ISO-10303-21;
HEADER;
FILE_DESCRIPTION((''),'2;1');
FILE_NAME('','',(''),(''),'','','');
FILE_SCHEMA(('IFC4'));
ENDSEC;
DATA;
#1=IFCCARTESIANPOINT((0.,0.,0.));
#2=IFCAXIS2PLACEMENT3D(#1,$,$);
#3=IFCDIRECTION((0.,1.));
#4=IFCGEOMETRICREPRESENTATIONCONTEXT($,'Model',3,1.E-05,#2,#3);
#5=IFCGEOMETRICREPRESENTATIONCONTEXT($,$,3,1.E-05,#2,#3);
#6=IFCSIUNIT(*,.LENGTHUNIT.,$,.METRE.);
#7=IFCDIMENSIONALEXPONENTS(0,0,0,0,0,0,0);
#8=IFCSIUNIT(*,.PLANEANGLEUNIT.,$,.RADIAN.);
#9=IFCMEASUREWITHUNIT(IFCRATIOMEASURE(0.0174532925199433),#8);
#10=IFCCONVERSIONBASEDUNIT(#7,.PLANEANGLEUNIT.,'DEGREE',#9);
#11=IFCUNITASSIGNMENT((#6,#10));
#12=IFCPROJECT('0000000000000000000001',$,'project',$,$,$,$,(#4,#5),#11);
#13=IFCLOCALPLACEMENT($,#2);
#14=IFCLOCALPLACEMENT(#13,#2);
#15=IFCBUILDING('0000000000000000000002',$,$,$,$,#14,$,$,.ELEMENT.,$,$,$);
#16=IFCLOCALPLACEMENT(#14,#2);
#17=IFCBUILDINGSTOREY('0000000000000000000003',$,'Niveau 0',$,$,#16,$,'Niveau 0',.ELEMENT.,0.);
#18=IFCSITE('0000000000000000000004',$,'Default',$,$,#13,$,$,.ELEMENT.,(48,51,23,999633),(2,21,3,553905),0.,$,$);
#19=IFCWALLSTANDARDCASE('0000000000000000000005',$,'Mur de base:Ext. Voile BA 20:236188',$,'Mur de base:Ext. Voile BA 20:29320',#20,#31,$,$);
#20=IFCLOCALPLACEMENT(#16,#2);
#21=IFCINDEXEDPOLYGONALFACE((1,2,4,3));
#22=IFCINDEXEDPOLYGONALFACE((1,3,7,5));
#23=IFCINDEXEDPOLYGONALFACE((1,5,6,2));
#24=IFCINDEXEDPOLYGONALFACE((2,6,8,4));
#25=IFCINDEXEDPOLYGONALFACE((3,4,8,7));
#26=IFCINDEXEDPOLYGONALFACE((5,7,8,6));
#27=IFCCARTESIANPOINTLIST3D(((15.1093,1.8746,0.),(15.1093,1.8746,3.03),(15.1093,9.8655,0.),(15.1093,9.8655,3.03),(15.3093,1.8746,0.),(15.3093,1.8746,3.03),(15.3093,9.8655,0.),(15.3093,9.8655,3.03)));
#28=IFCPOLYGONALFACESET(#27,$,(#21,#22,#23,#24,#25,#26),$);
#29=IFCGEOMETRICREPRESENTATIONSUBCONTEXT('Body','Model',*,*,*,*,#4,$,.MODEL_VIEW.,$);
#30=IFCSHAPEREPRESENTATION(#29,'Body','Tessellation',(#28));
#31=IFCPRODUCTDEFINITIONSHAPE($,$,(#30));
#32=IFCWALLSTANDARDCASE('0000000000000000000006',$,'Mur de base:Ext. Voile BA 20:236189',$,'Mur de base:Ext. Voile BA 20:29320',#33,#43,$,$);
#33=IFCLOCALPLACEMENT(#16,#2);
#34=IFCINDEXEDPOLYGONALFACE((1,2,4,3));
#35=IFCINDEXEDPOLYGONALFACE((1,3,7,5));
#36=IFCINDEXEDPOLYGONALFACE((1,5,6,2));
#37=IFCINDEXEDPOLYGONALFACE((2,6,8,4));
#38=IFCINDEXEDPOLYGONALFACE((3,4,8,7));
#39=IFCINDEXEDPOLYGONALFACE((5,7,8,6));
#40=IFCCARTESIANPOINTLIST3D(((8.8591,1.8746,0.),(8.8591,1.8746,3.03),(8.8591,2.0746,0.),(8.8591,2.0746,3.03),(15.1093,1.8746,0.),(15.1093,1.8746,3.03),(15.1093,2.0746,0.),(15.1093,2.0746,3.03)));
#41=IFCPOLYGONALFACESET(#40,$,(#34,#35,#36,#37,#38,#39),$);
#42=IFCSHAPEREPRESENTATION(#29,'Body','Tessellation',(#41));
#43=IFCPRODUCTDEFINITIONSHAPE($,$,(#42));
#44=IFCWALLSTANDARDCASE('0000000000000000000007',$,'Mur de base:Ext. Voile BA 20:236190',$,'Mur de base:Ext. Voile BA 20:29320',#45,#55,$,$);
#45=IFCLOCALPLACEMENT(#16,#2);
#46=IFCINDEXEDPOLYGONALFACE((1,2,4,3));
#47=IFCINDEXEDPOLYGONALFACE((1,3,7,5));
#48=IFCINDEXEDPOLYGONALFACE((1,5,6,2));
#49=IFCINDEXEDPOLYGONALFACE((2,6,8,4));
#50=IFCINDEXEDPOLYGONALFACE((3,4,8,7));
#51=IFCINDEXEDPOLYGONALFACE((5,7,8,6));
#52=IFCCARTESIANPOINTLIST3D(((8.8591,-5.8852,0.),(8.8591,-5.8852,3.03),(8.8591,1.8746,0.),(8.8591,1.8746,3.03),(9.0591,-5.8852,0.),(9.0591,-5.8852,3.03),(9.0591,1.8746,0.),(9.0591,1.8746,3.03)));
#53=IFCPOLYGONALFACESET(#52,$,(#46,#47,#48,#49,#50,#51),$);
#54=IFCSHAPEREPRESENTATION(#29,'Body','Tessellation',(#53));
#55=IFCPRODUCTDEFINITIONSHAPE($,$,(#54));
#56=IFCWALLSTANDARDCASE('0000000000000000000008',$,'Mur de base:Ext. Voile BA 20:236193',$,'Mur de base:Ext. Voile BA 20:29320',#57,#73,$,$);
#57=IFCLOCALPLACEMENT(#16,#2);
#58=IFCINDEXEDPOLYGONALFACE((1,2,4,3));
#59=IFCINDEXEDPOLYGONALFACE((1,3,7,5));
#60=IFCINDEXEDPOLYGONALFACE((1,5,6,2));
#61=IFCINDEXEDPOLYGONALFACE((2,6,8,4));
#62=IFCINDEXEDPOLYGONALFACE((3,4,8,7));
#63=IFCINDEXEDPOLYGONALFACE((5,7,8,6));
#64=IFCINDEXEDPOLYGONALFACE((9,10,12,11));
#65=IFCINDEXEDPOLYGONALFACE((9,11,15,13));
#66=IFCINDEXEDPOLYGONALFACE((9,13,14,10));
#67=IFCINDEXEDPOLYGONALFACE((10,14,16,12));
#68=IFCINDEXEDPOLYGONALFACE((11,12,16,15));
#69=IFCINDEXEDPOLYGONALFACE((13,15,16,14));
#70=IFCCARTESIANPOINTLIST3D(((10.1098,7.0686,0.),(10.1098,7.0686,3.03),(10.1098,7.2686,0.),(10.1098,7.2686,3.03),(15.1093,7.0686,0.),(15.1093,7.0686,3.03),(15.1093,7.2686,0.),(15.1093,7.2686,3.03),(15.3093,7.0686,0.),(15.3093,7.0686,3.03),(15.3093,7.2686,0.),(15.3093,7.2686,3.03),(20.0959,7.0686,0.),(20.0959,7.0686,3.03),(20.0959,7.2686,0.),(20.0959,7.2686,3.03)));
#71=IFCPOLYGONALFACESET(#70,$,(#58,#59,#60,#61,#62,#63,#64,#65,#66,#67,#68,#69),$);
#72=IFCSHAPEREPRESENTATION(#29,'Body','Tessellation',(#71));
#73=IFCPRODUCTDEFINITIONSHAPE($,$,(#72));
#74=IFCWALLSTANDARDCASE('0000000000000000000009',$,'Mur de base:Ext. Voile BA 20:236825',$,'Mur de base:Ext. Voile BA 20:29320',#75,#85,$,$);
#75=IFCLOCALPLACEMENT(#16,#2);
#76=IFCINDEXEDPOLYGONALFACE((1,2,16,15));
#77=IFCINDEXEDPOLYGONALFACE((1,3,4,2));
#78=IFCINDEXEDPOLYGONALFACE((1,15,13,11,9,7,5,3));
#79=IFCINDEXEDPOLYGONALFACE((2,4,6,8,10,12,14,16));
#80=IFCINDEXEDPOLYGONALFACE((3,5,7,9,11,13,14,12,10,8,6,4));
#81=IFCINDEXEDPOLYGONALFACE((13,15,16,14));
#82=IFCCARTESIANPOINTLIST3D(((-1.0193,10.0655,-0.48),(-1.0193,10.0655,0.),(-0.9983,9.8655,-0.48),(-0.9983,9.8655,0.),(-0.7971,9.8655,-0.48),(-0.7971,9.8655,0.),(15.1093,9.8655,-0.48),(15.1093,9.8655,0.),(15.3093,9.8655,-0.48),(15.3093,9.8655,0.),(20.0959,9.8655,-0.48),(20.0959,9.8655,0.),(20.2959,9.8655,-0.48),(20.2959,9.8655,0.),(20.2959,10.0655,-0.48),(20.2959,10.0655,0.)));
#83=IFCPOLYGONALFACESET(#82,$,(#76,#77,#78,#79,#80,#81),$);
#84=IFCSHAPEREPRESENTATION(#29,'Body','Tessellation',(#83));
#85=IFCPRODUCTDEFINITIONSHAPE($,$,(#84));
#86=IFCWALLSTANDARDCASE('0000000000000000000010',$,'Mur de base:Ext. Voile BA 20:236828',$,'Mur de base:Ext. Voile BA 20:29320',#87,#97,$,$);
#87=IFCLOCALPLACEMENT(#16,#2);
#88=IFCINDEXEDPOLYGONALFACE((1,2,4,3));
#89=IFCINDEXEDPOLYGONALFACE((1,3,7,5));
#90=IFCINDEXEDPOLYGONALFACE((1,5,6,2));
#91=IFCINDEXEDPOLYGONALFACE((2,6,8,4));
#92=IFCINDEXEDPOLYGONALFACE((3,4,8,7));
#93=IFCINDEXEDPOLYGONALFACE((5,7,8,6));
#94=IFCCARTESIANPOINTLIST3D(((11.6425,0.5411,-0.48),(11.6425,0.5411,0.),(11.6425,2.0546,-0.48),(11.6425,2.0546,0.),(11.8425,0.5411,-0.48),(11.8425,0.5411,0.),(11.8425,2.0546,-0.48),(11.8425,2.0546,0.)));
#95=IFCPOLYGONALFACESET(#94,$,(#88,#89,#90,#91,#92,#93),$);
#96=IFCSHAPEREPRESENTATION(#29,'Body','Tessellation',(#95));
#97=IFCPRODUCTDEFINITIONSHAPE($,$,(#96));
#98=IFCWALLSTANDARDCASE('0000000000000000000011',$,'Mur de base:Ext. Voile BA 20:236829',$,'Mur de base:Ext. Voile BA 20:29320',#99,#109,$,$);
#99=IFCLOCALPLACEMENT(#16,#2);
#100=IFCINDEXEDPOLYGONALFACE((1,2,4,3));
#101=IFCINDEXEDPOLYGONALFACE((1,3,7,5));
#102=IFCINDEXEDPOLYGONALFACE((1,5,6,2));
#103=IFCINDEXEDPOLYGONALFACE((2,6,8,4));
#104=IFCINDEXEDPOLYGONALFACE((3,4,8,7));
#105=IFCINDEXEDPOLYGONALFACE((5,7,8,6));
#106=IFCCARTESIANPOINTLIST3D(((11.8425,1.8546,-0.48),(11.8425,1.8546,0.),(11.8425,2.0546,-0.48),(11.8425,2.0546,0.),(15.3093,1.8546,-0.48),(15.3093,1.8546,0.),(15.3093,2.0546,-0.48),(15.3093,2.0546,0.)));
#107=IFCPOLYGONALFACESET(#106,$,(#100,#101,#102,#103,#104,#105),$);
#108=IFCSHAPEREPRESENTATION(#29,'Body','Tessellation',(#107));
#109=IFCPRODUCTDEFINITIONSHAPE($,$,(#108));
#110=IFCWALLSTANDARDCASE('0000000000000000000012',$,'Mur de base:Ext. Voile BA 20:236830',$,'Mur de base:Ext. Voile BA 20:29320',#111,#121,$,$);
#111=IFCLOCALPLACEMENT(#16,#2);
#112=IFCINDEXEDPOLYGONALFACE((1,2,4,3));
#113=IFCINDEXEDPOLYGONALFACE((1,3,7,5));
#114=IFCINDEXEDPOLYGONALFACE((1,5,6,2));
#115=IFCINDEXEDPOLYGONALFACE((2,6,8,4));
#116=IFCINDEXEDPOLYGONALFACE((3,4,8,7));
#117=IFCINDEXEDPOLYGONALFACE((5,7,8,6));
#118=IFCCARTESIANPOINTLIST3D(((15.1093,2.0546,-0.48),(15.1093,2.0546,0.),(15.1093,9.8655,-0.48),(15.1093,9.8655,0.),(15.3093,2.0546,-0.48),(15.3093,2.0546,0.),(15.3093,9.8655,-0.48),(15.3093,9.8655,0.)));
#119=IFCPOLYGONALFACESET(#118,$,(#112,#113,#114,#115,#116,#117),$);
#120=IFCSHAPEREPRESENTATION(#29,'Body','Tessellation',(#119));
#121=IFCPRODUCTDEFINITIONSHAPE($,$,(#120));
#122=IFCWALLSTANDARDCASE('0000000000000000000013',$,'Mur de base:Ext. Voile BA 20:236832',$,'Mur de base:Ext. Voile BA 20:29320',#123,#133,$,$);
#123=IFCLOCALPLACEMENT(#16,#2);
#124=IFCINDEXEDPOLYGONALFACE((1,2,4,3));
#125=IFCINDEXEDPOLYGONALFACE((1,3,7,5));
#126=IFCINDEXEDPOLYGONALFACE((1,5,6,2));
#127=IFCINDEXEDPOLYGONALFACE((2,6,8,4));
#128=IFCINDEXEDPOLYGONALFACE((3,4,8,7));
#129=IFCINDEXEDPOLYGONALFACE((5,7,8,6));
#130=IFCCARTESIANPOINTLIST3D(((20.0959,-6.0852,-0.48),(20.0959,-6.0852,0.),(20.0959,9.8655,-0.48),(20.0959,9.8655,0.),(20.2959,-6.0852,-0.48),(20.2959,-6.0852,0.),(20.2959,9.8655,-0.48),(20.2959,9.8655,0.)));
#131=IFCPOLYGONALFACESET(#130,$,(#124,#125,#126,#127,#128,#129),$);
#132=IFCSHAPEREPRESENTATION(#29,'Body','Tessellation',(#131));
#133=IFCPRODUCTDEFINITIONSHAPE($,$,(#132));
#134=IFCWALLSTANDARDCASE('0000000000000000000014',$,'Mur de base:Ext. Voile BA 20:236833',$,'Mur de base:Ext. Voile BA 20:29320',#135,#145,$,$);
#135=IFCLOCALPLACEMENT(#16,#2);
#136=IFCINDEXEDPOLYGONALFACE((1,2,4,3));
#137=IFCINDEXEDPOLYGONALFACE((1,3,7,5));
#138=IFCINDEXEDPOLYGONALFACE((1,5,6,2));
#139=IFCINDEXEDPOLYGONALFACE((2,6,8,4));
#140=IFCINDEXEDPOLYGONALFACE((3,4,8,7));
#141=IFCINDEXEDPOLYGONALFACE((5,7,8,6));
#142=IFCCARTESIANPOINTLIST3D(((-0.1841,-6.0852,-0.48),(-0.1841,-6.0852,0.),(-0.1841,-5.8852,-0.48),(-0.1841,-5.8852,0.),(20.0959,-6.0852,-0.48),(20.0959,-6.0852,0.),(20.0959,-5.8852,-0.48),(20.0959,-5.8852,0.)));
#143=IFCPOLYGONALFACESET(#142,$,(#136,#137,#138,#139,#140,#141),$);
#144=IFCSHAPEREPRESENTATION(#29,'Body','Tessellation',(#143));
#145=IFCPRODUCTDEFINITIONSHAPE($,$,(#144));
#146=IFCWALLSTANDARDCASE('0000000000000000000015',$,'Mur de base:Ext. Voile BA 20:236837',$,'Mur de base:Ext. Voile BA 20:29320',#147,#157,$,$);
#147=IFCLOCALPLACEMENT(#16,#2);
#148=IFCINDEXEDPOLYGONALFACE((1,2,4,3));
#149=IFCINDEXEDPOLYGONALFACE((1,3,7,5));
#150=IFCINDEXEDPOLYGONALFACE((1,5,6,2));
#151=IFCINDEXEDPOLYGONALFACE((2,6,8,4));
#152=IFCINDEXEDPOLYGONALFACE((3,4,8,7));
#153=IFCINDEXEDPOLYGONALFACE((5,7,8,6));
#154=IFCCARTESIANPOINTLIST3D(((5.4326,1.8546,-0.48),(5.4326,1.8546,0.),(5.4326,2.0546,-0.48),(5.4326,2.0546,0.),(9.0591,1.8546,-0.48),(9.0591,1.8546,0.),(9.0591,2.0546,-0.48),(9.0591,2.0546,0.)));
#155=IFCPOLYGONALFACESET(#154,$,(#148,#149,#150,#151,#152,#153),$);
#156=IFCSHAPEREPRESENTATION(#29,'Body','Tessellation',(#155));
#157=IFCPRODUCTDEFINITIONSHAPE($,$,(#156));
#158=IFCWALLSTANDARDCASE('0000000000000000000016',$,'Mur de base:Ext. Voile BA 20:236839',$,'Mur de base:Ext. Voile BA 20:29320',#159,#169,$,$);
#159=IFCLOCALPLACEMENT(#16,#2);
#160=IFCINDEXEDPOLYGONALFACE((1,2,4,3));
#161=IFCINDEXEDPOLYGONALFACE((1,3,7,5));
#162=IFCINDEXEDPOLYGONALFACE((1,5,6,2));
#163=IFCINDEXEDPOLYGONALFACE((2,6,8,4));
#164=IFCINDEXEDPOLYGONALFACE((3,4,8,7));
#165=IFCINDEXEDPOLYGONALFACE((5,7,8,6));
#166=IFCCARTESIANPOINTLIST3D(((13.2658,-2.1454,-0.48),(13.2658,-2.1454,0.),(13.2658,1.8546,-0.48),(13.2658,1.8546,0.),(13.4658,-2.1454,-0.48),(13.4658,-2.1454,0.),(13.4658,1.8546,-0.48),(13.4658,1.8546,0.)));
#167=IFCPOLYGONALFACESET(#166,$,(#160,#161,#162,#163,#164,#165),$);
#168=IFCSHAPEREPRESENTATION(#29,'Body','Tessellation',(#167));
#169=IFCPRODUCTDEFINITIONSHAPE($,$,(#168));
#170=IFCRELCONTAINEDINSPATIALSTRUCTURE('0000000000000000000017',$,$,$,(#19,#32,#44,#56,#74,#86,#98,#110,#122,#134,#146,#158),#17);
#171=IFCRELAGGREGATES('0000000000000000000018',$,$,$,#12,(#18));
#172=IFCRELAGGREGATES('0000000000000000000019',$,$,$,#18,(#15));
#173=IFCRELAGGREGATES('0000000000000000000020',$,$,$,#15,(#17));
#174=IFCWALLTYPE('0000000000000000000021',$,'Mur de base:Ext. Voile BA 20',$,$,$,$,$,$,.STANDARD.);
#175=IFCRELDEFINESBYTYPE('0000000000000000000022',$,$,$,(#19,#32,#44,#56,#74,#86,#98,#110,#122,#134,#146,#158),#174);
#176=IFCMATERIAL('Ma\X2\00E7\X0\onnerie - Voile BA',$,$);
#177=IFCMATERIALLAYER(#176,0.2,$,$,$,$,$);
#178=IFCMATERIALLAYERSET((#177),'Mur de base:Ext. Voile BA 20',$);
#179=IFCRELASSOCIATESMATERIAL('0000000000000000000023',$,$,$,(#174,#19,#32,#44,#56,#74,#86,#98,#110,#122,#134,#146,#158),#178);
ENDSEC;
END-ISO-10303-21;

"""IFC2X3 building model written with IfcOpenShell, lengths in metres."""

from ifc_helpers import new_model, entity, si_unit, converted_unit, direction, frame, frame_2d, origin, origin_2d_with_axis, place, context, subcontext, project, spatial, polyline, rectangle, outline, extrude, material, layer, layer_set, layer_usage, type_object, element, save


model = new_model("IFC2X3")

# Units and contexts
model_context = context("Model", 3, precision=1e-05, world=origin(), true_north=direction((0.0, 1.0)))
context_of_model = context(None, 3, precision=1e-05, world=origin(), true_north=direction((0.0, 1.0)))
body_context = subcontext(model_context, "Body", "Model", "MODEL_VIEW")
ifc_project = project(units=[si_unit("LENGTHUNIT", "METRE"), converted_unit("PLANEANGLEUNIT", "DEGREE", entity("IfcRatioMeasure", 0.0174532925199433), si_unit("PLANEANGLEUNIT", "RADIAN"), dimensions=[0, 0, 0, 0, 0, 0, 0])], contexts=[model_context, context_of_model])

# Site, building, storey
site_placement = place(None, origin())
site = spatial("IfcSite", under=ifc_project, at=site_placement, Name="Default", CompositionType="ELEMENT", RefLatitude=(48, 51, 23, 999633), RefLongitude=(2, 21, 3, 553905), RefElevation=0.0)
building_placement = place(site_placement, origin())
building = spatial("IfcBuilding", under=site, at=building_placement, CompositionType="ELEMENT")
storey_placement = place(building_placement, origin())
storey = spatial("IfcBuildingStorey", under=building, at=storey_placement, Name="Niveau 0", LongName="Niveau 0", CompositionType="ELEMENT", Elevation=0.0)

# Shared definitions
ifc_material = material(Name="Maçonnerie - Voile BA")
ifc_layer = layer(ifc_material, 0.2)
ifc_layer_set = layer_set([ifc_layer], Name="Mur de base:Ext. Voile BA 20")
wall_type = type_object("IfcWallType", Name="Mur de base:Ext. Voile BA 20", PredefinedType="STANDARD", material=ifc_layer_set)

# Walls
ifc_layer_usage_1 = layer_usage(ifc_layer_set, "AXIS2", "NEGATIVE", 0.1)
wall_1_placement = place(storey_placement, frame((15.2093, 9.8655, 0.0), z_axis=(0.0, 0.0, 1.0), x_axis=(0.0, -1.0, 0.0)))
element("IfcWallStandardCase", 1, at=wall_1_placement, inside=storey, type_object=wall_type, material=ifc_layer_usage_1, Name="Mur de base:Ext. Voile BA 20:236188", ObjectType="Mur de base:Ext. Voile BA 20:29320", context=body_context, shape_type="SweptSolid", body=[
    extrude(rectangle(XDim=7.9908, YDim=0.2, at=frame_2d((3.9954, 0.0), x_axis=(-1.0, 0.0))), origin(), (0.0, 0.0, 1.0), 3.03),
])
ifc_layer_usage_2 = layer_usage(ifc_layer_set, "AXIS2", "NEGATIVE", 0.1)
wall_2_placement = place(storey_placement, frame((15.1093, 1.9746, 0.0), z_axis=(0.0, 0.0, 1.0), x_axis=(-1.0, 0.0, 0.0)))
element("IfcWallStandardCase", 2, at=wall_2_placement, inside=storey, type_object=wall_type, material=ifc_layer_usage_2, Name="Mur de base:Ext. Voile BA 20:236189", ObjectType="Mur de base:Ext. Voile BA 20:29320", context=body_context, shape_type="SweptSolid", body=[
    extrude(rectangle(XDim=6.2503, YDim=0.2, at=frame_2d((3.1251, 0.0), x_axis=(-1.0, 0.0))), origin(), (0.0, 0.0, 1.0), 3.03),
])
ifc_layer_usage_3 = layer_usage(ifc_layer_set, "AXIS2", "NEGATIVE", 0.1)
wall_3_placement = place(storey_placement, frame((8.9591, 1.8746, 0.0), z_axis=(0.0, 0.0, 1.0), x_axis=(0.0, -1.0, 0.0)))
element("IfcWallStandardCase", 3, at=wall_3_placement, inside=storey, type_object=wall_type, material=ifc_layer_usage_3, Name="Mur de base:Ext. Voile BA 20:236190", ObjectType="Mur de base:Ext. Voile BA 20:29320", context=body_context, shape_type="SweptSolid", body=[
    extrude(rectangle(XDim=7.7598, YDim=0.2, at=frame_2d((3.8799, 0.0), x_axis=(-1.0, 0.0))), origin(), (0.0, 0.0, 1.0), 3.03),
])

# Wall, opening
ifc_layer_usage_4 = layer_usage(ifc_layer_set, "AXIS2", "NEGATIVE", 0.1)
wall_4_placement = place(storey_placement, frame((20.0959, 7.1686, 0.0), z_axis=(0.0, 0.0, 1.0), x_axis=(-1.0, 0.0, 0.0)))
wall_4 = element("IfcWallStandardCase", 4, at=wall_4_placement, inside=storey, type_object=wall_type, material=ifc_layer_usage_4, Name="Mur de base:Ext. Voile BA 20:236193", ObjectType="Mur de base:Ext. Voile BA 20:29320", context=body_context, shape_type="SweptSolid", body=[
    extrude(rectangle(XDim=9.9862, YDim=0.2, at=frame_2d((4.9931, 0.0), x_axis=(-1.0, 0.0))), origin(), (0.0, 0.0, 1.0), 3.03),
])
opening_1_placement = place(storey_placement, frame((20.0959, 7.1686, 0.0), z_axis=(0.0, 0.0, 1.0), x_axis=(-1.0, 0.0, 0.0)))
element("IfcOpeningElement", 5, at=opening_1_placement, cuts=wall_4, ObjectType="Opening", context=body_context, shape_type="SweptSolid", body=[
    extrude(rectangle(XDim=3.03, YDim=0.2, at=origin_2d_with_axis()), frame((4.9866, 0.0, 1.515), z_axis=(-1.0, 0.0, 0.0), x_axis=(0.0, 0.0, 1.0)), (0.0, 0.0, 1.0), 0.2),
])

# Walls
ifc_layer_usage_5 = layer_usage(ifc_layer_set, "AXIS2", "NEGATIVE", 0.1)
wall_5_placement = place(storey_placement, frame((20.2959, 9.9655, -0.48), z_axis=(0.0, 0.0, 1.0), x_axis=(-1.0, 0.0, 0.0)))
element("IfcWallStandardCase", 6, at=wall_5_placement, inside=storey, type_object=wall_type, material=ifc_layer_usage_5, Name="Mur de base:Ext. Voile BA 20:236825", ObjectType="Mur de base:Ext. Voile BA 20:29320", context=body_context, shape_type="SweptSolid", body=[
    extrude(outline(polyline([(21.3152, -0.1), (21.2942, 0.1), (21.0931, 0.1), (5.1866, 0.1), (4.9866, 0.1), (0.2, 0.1), (0.0, 0.1), (0.0, -0.1), (21.3152, -0.1)])), origin(), (0.0, 0.0, 1.0), 0.48),
])
ifc_layer_usage_6 = layer_usage(ifc_layer_set, "AXIS2", "NEGATIVE", 0.1)
wall_6_placement = place(storey_placement, frame((11.7425, 0.5411, -0.48), z_axis=(0.0, 0.0, 1.0), x_axis=(0.0, 1.0, 0.0)))
element("IfcWallStandardCase", 7, at=wall_6_placement, inside=storey, type_object=wall_type, material=ifc_layer_usage_6, Name="Mur de base:Ext. Voile BA 20:236828", ObjectType="Mur de base:Ext. Voile BA 20:29320", context=body_context, shape_type="SweptSolid", body=[
    extrude(rectangle(XDim=1.5134, YDim=0.2, at=frame_2d((0.7567, 0.0), x_axis=(-1.0, 0.0))), origin(), (0.0, 0.0, 1.0), 0.48),
])
ifc_layer_usage_7 = layer_usage(ifc_layer_set, "AXIS2", "NEGATIVE", 0.1)
wall_7_placement = place(storey_placement, frame((11.8425, 1.9546, -0.48)))
element("IfcWallStandardCase", 8, at=wall_7_placement, inside=storey, type_object=wall_type, material=ifc_layer_usage_7, Name="Mur de base:Ext. Voile BA 20:236829", ObjectType="Mur de base:Ext. Voile BA 20:29320", context=body_context, shape_type="SweptSolid", body=[
    extrude(rectangle(XDim=3.4668, YDim=0.2, at=frame_2d((1.7334, 0.0), x_axis=(-1.0, 0.0))), origin(), (0.0, 0.0, 1.0), 0.48),
])
ifc_layer_usage_8 = layer_usage(ifc_layer_set, "AXIS2", "NEGATIVE", 0.1)
wall_8_placement = place(storey_placement, frame((15.2093, 2.0546, -0.48), z_axis=(0.0, 0.0, 1.0), x_axis=(0.0, 1.0, 0.0)))
element("IfcWallStandardCase", 9, at=wall_8_placement, inside=storey, type_object=wall_type, material=ifc_layer_usage_8, Name="Mur de base:Ext. Voile BA 20:236830", ObjectType="Mur de base:Ext. Voile BA 20:29320", context=body_context, shape_type="SweptSolid", body=[
    extrude(rectangle(XDim=7.8109, YDim=0.2, at=frame_2d((3.9054, 0.0), x_axis=(-1.0, 0.0))), origin(), (0.0, 0.0, 1.0), 0.48),
])
ifc_layer_usage_9 = layer_usage(ifc_layer_set, "AXIS2", "NEGATIVE", 0.1)
wall_9_placement = place(storey_placement, frame((20.1959, 9.8655, -0.48), z_axis=(0.0, 0.0, 1.0), x_axis=(0.0, -1.0, 0.0)))
element("IfcWallStandardCase", 10, at=wall_9_placement, inside=storey, type_object=wall_type, material=ifc_layer_usage_9, Name="Mur de base:Ext. Voile BA 20:236832", ObjectType="Mur de base:Ext. Voile BA 20:29320", context=body_context, shape_type="SweptSolid", body=[
    extrude(rectangle(XDim=15.9506, YDim=0.2, at=frame_2d((7.9753, 0.0), x_axis=(-1.0, 0.0))), origin(), (0.0, 0.0, 1.0), 0.48),
])
ifc_layer_usage_10 = layer_usage(ifc_layer_set, "AXIS2", "NEGATIVE", 0.1)
wall_10_placement = place(storey_placement, frame((20.0959, -5.9852, -0.48), z_axis=(0.0, 0.0, 1.0), x_axis=(-1.0, 0.0, 0.0)))
element("IfcWallStandardCase", 11, at=wall_10_placement, inside=storey, type_object=wall_type, material=ifc_layer_usage_10, Name="Mur de base:Ext. Voile BA 20:236833", ObjectType="Mur de base:Ext. Voile BA 20:29320", context=body_context, shape_type="SweptSolid", body=[
    extrude(rectangle(XDim=20.28, YDim=0.2, at=frame_2d((10.14, 0.0), x_axis=(-1.0, 0.0))), origin(), (0.0, 0.0, 1.0), 0.48),
])
ifc_layer_usage_11 = layer_usage(ifc_layer_set, "AXIS2", "NEGATIVE", 0.1)
wall_11_placement = place(storey_placement, frame((9.0591, 1.9546, -0.48), z_axis=(0.0, 0.0, 1.0), x_axis=(-1.0, 0.0, 0.0)))
element("IfcWallStandardCase", 12, at=wall_11_placement, inside=storey, type_object=wall_type, material=ifc_layer_usage_11, Name="Mur de base:Ext. Voile BA 20:236837", ObjectType="Mur de base:Ext. Voile BA 20:29320", context=body_context, shape_type="SweptSolid", body=[
    extrude(rectangle(XDim=3.6265, YDim=0.2, at=frame_2d((1.8132, 0.0), x_axis=(-1.0, 0.0))), origin(), (0.0, 0.0, 1.0), 0.48),
])
ifc_layer_usage_12 = layer_usage(ifc_layer_set, "AXIS2", "NEGATIVE", 0.1)
wall_12_placement = place(storey_placement, frame((13.3658, 1.8546, -0.48), z_axis=(0.0, 0.0, 1.0), x_axis=(0.0, -1.0, 0.0)))
element("IfcWallStandardCase", 13, at=wall_12_placement, inside=storey, type_object=wall_type, material=ifc_layer_usage_12, Name="Mur de base:Ext. Voile BA 20:236839", ObjectType="Mur de base:Ext. Voile BA 20:29320", context=body_context, shape_type="SweptSolid", body=[
    extrude(rectangle(XDim=4.0, YDim=0.2, at=frame_2d((2.0, 0.0), x_axis=(-1.0, 0.0))), origin(), (0.0, 0.0, 1.0), 0.48),
])

save(model, "model.ifc")
